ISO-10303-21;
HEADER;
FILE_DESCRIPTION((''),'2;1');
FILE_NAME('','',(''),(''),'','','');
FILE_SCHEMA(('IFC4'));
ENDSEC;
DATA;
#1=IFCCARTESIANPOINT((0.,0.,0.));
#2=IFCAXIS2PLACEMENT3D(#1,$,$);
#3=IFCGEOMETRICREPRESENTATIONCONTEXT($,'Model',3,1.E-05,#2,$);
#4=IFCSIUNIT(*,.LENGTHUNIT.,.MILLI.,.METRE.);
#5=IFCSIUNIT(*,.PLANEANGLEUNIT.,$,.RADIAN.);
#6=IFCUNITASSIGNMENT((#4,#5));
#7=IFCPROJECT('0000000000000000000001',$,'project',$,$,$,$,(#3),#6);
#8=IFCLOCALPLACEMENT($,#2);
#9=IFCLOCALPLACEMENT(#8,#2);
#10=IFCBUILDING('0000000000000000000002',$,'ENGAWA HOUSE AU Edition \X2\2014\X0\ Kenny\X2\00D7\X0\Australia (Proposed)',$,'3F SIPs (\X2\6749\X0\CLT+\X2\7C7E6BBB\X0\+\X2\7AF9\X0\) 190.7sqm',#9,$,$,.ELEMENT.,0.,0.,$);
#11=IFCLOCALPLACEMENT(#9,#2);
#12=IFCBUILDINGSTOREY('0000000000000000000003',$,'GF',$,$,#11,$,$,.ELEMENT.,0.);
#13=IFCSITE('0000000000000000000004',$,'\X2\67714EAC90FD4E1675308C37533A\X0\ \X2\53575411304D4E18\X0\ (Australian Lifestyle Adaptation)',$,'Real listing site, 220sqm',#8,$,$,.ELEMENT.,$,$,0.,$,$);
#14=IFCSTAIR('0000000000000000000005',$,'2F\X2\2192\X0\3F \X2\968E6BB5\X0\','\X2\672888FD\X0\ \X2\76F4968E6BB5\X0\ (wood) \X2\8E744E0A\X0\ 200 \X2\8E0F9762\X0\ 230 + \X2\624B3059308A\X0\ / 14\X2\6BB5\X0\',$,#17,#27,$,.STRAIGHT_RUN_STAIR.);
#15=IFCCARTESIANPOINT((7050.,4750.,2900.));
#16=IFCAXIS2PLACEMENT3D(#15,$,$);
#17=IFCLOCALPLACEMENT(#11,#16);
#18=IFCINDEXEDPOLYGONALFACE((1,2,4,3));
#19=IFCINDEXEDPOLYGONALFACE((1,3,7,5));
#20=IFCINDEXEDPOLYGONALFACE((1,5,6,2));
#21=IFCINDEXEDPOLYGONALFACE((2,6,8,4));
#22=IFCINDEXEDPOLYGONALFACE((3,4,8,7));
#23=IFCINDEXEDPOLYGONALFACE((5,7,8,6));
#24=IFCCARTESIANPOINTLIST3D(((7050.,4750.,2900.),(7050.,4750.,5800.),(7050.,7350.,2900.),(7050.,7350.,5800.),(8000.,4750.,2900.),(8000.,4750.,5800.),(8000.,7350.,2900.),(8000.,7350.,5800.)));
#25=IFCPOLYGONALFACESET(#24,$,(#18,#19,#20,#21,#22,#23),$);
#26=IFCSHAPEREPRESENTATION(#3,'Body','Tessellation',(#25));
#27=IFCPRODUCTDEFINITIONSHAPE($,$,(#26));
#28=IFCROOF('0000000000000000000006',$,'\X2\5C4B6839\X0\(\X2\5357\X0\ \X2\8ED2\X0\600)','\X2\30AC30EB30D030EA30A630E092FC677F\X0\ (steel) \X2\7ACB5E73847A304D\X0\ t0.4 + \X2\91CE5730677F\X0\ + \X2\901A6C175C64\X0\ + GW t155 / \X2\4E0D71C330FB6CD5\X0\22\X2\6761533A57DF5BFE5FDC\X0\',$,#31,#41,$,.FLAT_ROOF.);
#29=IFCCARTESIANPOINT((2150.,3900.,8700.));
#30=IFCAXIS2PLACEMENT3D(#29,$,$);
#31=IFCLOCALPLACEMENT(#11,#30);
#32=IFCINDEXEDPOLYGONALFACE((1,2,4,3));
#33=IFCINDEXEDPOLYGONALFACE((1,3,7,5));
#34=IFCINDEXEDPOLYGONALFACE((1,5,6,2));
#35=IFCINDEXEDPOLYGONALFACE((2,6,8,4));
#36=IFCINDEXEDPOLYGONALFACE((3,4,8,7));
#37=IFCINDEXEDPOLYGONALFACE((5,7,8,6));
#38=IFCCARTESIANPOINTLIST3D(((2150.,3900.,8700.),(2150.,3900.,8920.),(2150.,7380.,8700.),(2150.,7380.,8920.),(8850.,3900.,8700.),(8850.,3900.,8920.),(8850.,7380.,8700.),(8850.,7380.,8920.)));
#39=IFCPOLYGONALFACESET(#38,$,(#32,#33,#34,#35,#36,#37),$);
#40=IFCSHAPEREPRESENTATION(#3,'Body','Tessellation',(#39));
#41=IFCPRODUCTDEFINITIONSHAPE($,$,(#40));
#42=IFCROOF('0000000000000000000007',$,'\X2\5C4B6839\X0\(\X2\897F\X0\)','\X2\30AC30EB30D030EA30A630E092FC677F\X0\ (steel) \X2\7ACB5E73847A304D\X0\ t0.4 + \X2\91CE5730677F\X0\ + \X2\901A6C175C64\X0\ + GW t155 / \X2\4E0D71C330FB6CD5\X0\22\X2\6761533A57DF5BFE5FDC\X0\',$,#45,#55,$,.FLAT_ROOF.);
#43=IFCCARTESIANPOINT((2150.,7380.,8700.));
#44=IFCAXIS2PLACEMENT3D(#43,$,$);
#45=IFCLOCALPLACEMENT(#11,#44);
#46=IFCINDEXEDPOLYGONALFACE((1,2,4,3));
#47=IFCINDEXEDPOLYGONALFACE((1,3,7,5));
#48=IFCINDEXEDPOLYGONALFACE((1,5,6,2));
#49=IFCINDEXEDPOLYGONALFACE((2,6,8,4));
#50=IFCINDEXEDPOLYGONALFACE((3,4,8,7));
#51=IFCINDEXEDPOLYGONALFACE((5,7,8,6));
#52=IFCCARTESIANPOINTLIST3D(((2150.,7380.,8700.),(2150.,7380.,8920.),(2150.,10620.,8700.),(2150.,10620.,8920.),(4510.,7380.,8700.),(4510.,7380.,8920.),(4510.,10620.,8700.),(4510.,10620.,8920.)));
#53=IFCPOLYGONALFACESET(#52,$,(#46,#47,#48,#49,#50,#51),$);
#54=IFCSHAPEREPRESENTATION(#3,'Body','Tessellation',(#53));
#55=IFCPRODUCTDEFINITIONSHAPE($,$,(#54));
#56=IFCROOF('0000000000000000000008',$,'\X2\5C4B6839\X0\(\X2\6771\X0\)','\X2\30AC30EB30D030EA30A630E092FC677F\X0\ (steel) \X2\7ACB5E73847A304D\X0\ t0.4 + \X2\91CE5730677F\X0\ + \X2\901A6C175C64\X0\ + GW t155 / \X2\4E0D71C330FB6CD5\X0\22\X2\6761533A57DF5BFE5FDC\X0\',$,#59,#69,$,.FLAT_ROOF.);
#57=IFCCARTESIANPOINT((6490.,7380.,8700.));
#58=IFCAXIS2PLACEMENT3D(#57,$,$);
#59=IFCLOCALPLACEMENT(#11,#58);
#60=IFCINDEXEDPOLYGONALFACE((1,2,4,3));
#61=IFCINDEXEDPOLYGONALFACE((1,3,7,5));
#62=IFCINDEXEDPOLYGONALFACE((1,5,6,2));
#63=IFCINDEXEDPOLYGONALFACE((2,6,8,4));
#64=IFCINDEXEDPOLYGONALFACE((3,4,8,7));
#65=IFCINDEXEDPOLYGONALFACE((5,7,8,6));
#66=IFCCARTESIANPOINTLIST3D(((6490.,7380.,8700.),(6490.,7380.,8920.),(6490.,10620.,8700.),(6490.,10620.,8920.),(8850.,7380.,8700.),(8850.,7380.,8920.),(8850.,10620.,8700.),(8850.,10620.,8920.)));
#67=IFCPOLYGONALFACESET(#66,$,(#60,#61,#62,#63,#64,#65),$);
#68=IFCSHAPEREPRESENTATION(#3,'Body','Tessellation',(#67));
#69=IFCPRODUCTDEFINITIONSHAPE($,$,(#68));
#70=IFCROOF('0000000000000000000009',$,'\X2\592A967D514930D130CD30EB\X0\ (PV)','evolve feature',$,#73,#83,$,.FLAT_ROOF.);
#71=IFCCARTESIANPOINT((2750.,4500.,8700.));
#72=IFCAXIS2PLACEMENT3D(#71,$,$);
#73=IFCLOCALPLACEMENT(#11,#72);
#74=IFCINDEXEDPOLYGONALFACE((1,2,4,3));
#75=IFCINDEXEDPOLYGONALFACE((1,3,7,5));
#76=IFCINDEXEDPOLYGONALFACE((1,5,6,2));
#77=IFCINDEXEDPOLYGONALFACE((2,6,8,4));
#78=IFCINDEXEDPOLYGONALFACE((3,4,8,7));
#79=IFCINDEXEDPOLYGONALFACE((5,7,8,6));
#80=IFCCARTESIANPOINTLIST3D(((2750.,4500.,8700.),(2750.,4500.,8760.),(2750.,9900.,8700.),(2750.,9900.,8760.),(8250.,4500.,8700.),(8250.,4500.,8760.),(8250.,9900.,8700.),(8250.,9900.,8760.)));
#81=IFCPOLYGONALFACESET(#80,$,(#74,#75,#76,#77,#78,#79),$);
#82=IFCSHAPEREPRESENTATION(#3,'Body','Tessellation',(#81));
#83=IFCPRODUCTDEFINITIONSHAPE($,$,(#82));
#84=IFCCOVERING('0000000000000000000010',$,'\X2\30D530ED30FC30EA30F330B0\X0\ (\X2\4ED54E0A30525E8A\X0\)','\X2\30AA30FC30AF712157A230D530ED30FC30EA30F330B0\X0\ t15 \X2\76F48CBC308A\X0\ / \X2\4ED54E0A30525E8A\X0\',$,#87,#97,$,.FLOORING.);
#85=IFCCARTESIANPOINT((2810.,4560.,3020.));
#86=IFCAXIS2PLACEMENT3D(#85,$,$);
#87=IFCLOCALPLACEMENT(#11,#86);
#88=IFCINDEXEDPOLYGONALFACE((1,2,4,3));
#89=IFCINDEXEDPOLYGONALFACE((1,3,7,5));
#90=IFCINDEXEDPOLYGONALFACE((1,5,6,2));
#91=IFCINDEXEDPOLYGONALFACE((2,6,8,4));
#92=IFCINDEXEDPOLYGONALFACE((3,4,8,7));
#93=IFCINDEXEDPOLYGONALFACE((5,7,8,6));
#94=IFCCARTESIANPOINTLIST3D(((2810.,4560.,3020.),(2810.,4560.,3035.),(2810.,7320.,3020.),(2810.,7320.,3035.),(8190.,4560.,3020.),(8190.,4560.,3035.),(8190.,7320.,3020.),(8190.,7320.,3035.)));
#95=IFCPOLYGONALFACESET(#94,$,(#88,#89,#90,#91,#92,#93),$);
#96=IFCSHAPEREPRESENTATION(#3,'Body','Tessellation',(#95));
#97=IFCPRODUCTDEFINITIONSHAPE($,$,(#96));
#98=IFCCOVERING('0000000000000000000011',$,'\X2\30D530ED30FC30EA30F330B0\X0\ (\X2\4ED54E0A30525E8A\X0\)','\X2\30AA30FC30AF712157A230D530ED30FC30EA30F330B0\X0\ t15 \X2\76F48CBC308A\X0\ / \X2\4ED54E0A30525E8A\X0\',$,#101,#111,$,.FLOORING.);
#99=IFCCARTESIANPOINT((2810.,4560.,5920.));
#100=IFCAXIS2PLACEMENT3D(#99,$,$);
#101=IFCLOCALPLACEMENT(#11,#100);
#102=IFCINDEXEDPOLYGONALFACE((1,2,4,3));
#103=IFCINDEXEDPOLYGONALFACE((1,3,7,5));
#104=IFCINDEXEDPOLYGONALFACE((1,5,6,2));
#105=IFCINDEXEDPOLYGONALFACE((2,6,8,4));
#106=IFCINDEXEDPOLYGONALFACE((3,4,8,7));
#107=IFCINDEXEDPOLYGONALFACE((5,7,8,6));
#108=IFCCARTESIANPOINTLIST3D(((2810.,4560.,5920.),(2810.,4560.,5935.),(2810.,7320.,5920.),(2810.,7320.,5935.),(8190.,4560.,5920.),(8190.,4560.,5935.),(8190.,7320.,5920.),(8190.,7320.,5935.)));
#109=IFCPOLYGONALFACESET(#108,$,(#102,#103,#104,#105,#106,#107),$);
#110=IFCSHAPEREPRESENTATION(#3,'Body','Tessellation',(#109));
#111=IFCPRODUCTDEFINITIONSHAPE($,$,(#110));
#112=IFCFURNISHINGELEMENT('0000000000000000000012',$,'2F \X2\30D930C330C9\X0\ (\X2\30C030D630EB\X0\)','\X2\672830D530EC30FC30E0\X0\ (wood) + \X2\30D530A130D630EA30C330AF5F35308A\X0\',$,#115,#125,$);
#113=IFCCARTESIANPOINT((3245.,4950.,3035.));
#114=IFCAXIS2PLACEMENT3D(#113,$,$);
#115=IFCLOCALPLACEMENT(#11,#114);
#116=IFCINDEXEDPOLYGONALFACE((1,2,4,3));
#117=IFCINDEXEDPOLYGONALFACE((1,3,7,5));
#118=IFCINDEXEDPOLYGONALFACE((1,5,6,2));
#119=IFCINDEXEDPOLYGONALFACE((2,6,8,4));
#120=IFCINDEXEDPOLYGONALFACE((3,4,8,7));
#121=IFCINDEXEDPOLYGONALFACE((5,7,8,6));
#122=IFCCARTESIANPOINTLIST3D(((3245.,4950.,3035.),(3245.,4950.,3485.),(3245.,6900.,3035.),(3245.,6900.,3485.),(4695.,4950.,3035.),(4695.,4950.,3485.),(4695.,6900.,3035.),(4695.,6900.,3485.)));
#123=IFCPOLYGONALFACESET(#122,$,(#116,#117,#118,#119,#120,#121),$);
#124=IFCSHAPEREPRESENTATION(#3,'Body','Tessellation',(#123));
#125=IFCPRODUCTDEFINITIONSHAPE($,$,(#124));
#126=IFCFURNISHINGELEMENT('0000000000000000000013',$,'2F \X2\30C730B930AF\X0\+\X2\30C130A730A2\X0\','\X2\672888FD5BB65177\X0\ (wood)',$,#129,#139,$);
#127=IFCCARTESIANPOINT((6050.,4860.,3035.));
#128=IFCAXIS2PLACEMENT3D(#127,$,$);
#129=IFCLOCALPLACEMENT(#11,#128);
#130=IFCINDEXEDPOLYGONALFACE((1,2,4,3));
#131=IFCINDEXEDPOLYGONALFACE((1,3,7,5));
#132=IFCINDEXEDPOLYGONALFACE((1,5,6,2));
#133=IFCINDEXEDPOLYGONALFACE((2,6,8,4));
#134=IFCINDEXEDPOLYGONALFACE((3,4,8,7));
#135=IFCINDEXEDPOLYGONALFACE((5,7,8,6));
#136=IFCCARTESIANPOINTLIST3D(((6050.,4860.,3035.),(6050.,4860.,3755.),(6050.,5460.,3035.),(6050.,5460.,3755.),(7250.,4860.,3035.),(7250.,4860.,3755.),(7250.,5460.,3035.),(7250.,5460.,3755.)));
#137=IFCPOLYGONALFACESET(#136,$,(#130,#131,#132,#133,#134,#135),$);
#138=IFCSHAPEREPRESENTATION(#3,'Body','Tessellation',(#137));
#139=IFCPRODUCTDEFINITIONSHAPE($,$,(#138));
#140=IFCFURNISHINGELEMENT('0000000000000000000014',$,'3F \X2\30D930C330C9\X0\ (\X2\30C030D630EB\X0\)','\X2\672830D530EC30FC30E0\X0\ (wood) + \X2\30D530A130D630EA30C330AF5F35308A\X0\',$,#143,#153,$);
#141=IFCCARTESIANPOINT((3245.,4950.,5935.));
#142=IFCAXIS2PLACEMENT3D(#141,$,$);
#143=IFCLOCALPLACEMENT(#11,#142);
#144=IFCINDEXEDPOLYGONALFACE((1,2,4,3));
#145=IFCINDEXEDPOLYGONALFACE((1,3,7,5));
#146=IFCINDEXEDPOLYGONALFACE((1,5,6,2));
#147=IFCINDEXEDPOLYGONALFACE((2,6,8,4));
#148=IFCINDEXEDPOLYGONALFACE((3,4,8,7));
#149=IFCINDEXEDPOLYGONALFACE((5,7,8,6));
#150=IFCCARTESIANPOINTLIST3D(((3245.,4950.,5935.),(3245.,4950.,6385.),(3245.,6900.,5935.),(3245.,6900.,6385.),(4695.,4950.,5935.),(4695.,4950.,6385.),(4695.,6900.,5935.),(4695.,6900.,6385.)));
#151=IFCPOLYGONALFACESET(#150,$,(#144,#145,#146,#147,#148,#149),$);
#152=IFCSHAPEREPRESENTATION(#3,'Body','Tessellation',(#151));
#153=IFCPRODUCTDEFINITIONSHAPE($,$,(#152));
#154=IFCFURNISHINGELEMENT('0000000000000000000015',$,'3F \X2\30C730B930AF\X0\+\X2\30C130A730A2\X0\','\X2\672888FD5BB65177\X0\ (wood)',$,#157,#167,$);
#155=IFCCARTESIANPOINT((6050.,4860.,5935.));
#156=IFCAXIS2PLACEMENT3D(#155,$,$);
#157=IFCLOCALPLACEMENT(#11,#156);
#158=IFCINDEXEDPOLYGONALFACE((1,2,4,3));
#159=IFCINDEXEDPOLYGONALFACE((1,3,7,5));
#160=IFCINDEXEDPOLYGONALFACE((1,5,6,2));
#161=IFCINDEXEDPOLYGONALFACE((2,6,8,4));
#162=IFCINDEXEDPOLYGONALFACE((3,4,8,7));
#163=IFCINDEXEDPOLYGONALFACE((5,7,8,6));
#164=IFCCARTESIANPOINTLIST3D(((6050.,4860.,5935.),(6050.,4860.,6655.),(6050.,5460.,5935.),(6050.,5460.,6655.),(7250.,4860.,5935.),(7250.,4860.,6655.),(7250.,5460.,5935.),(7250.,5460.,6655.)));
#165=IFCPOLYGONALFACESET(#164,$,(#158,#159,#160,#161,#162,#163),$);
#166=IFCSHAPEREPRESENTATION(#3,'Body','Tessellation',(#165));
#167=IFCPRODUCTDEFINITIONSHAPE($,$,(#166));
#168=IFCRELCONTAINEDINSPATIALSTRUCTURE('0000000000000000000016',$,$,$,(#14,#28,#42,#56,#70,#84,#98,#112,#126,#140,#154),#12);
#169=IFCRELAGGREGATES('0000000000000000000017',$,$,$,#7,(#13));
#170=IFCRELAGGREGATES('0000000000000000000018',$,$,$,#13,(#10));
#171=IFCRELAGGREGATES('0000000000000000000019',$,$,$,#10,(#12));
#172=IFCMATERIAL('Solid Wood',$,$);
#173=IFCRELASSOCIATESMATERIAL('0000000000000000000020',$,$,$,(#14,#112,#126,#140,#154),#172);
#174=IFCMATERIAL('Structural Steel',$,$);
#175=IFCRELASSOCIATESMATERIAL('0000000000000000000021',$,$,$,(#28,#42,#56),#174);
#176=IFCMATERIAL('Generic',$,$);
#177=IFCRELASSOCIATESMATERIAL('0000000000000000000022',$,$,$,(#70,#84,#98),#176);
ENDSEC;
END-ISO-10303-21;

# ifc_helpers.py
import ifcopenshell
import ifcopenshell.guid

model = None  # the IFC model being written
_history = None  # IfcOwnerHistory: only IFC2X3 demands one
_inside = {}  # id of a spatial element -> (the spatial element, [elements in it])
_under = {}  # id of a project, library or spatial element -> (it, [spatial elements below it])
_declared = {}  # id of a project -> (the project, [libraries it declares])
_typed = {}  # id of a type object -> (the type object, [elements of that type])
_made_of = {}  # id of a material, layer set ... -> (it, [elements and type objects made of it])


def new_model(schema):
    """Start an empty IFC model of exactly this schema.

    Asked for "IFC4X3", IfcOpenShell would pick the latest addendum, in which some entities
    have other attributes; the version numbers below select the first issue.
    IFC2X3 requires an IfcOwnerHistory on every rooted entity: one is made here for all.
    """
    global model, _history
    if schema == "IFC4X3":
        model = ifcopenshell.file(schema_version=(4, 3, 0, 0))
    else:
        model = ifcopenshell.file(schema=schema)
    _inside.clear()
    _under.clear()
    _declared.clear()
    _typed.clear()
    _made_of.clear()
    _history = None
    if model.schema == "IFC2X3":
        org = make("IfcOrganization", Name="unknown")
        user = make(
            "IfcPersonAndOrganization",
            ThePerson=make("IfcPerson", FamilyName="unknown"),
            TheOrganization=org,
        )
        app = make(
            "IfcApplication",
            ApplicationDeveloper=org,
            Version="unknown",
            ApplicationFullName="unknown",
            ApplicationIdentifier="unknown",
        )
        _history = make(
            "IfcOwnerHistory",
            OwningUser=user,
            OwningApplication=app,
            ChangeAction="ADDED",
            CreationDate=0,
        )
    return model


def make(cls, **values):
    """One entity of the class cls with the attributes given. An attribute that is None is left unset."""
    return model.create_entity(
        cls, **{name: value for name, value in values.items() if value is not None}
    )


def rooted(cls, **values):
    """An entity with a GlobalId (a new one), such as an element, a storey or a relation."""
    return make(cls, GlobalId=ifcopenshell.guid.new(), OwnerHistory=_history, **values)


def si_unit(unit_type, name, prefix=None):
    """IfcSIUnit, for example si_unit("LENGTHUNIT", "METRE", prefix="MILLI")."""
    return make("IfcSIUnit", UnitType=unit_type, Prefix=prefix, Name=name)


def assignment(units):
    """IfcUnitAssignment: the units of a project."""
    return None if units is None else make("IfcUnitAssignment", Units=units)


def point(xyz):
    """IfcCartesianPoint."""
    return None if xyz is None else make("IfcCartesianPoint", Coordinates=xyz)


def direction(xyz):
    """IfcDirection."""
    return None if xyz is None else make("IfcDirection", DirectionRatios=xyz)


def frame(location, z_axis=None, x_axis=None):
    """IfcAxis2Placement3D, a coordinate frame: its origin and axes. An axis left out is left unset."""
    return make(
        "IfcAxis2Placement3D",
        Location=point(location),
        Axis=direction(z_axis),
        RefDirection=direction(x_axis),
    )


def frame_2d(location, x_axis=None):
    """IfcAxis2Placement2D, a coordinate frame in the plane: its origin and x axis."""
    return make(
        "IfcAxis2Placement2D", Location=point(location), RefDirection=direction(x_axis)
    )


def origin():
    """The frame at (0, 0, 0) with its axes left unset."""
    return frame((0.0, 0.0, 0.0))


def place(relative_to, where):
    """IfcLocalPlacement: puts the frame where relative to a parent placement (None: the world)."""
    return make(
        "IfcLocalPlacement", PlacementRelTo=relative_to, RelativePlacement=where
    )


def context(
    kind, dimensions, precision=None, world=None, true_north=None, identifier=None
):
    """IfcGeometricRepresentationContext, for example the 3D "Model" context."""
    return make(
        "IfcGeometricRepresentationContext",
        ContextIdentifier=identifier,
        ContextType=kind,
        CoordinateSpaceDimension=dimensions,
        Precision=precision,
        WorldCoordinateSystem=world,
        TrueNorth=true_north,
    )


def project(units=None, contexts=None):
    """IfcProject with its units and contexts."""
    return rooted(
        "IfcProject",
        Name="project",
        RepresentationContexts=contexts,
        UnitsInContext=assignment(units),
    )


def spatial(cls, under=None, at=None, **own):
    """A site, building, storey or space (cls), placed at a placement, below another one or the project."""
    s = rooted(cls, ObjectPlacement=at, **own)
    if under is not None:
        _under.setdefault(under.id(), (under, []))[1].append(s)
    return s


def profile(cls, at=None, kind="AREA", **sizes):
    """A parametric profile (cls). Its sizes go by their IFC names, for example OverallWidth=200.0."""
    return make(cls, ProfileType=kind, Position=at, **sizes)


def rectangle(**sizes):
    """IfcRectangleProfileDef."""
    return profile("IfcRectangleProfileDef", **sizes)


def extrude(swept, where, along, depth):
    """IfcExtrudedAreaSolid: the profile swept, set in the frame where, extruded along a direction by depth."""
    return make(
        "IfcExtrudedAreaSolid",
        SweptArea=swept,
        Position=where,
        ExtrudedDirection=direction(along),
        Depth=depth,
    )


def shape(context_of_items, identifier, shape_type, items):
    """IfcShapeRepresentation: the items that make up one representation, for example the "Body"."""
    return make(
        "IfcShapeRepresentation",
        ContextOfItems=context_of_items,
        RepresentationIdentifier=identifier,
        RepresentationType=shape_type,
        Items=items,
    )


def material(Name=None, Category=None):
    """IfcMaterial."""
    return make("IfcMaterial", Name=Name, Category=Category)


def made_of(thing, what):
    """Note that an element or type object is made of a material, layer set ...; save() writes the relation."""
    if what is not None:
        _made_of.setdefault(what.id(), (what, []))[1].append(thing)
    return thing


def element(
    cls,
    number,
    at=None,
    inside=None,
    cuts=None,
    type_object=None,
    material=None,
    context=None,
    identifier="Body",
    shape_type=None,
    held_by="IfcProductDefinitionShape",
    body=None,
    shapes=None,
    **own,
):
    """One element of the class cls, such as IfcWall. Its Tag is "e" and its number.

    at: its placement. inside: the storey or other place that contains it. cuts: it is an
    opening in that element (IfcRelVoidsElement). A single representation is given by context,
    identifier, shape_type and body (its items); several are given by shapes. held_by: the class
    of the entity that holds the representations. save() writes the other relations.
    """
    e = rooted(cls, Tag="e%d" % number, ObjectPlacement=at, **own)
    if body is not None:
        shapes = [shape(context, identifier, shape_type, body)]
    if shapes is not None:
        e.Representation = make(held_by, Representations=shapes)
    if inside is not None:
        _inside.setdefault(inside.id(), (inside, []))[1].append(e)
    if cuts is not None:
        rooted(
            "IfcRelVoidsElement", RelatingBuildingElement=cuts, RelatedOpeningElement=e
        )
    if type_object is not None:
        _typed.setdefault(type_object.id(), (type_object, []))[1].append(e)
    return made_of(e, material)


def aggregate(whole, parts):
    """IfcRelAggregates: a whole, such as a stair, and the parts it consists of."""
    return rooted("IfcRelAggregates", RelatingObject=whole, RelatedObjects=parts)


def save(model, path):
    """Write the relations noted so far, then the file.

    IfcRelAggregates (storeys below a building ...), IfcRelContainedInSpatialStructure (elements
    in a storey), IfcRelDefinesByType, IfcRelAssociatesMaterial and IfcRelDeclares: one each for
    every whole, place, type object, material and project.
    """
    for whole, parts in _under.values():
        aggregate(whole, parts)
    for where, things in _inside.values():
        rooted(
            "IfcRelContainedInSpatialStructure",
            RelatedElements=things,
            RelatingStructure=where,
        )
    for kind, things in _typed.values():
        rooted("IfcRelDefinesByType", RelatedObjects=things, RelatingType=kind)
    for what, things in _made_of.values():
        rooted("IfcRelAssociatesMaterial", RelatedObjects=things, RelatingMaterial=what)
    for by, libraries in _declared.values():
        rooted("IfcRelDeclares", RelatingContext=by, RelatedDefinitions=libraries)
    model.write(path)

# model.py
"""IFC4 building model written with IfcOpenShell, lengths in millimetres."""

from ifc_helpers import new_model, si_unit, frame, frame_2d, origin, place, context, project, spatial, rectangle, extrude, material, element, save


model = new_model("IFC4")

# Units and contexts
model_context = context("Model", 3, precision=1e-05, world=origin())
ifc_project = project(units=[si_unit("LENGTHUNIT", "METRE", prefix="MILLI"), si_unit("PLANEANGLEUNIT", "RADIAN")], contexts=[model_context])

# Site, building, storey
site_placement = place(None, origin())
site = spatial("IfcSite", under=ifc_project, at=site_placement, Name="東京都世田谷区 南向き丘 (Australian Lifestyle Adaptation)", ObjectType="Real listing site, 220sqm", CompositionType="ELEMENT", RefElevation=0.0)
building_placement = place(site_placement, origin())
building = spatial("IfcBuilding", under=site, at=building_placement, Name="ENGAWA HOUSE AU Edition — Kenny×Australia (Proposed)", ObjectType="3F SIPs (杉CLT+籾殻+竹) 190.7sqm", CompositionType="ELEMENT", ElevationOfRefHeight=0.0, ElevationOfTerrain=0.0)
storey_placement = place(building_placement, origin())
storey = spatial("IfcBuildingStorey", under=building, at=storey_placement, Name="GF", CompositionType="ELEMENT", Elevation=0.0)

# Shared definitions
ifc_material_1 = material(Name="Solid Wood")

# Stair
stair_placement = place(storey_placement, frame((7050.0, 4750.0, 2900.0)))
element("IfcStair", 1, at=stair_placement, inside=storey, material=ifc_material_1, Name="2F→3F 階段", Description="木製 直階段 (wood) 蹴上 200 踏面 230 + 手すり / 14段", PredefinedType="STRAIGHT_RUN_STAIR", context=model_context, shape_type="SweptSolid", body=[
    extrude(rectangle(XDim=950.0, YDim=2600.0, at=frame_2d((475.0, 1300.0))), frame((7050.0, 4750.0, 2900.0)), (0.0, 0.0, 1.0), 2900.0),
])

# Roofs
ifc_material_2 = material(Name="Structural Steel")
roof_1_placement = place(storey_placement, frame((2150.0, 3900.0, 8700.0)))
element("IfcRoof", 2, at=roof_1_placement, inside=storey, material=ifc_material_2, Name="屋根(南 軒600)", Description="ガルバリウム鋼板 (steel) 立平葺き t0.4 + 野地板 + 通気層 + GW t155 / 不燃・法22条区域対応", PredefinedType="FLAT_ROOF", context=model_context, shape_type="SweptSolid", body=[
    extrude(rectangle(XDim=6700.0, YDim=3480.0, at=frame_2d((3350.0, 1740.0))), frame((2150.0, 3900.0, 8700.0)), (0.0, 0.0, 1.0), 220.0),
])
roof_2_placement = place(storey_placement, frame((2150.0, 7380.0, 8700.0)))
element("IfcRoof", 3, at=roof_2_placement, inside=storey, material=ifc_material_2, Name="屋根(西)", Description="ガルバリウム鋼板 (steel) 立平葺き t0.4 + 野地板 + 通気層 + GW t155 / 不燃・法22条区域対応", PredefinedType="FLAT_ROOF", context=model_context, shape_type="SweptSolid", body=[
    extrude(rectangle(XDim=2360.0, YDim=3240.0, at=frame_2d((1180.0, 1620.0))), frame((2150.0, 7380.0, 8700.0)), (0.0, 0.0, 1.0), 220.0),
])
roof_3_placement = place(storey_placement, frame((6490.0, 7380.0, 8700.0)))
element("IfcRoof", 4, at=roof_3_placement, inside=storey, material=ifc_material_2, Name="屋根(東)", Description="ガルバリウム鋼板 (steel) 立平葺き t0.4 + 野地板 + 通気層 + GW t155 / 不燃・法22条区域対応", PredefinedType="FLAT_ROOF", context=model_context, shape_type="SweptSolid", body=[
    extrude(rectangle(XDim=2360.0, YDim=3240.0, at=frame_2d((1180.0, 1620.0))), frame((6490.0, 7380.0, 8700.0)), (0.0, 0.0, 1.0), 220.0),
])
ifc_material_3 = material(Name="Generic")
roof_4_placement = place(storey_placement, frame((2750.0, 4500.0, 8700.0)))
element("IfcRoof", 5, at=roof_4_placement, inside=storey, material=ifc_material_3, Name="太陽光パネル (PV)", Description="evolve feature", PredefinedType="FLAT_ROOF", context=model_context, shape_type="SweptSolid", body=[
    extrude(rectangle(XDim=5500.0, YDim=5400.0, at=frame_2d((2750.0, 2700.0))), frame((2750.0, 4500.0, 8700.0)), (0.0, 0.0, 1.0), 60.0),
])

# Coverings
covering_1_placement = place(storey_placement, frame((2810.0, 4560.0, 3020.0)))
element("IfcCovering", 6, at=covering_1_placement, inside=storey, material=ifc_material_3, Name="フローリング (仕上げ床)", Description="オーク無垢フローリング t15 直貼り / 仕上げ床", PredefinedType="FLOORING", context=model_context, shape_type="SweptSolid", body=[
    extrude(rectangle(XDim=5380.0, YDim=2760.0, at=frame_2d((2690.0, 1380.0))), frame((2810.0, 4560.0, 3020.0)), (0.0, 0.0, 1.0), 15.0),
])
covering_2_placement = place(storey_placement, frame((2810.0, 4560.0, 5920.0)))
element("IfcCovering", 7, at=covering_2_placement, inside=storey, material=ifc_material_3, Name="フローリング (仕上げ床)", Description="オーク無垢フローリング t15 直貼り / 仕上げ床", PredefinedType="FLOORING", context=model_context, shape_type="SweptSolid", body=[
    extrude(rectangle(XDim=5380.0, YDim=2760.0, at=frame_2d((2690.0, 1380.0))), frame((2810.0, 4560.0, 5920.0)), (0.0, 0.0, 1.0), 15.0),
])

# Furnishing elements
furnishing_1_placement = place(storey_placement, frame((3245.0, 4950.0, 3035.0)))
element("IfcFurnishingElement", 8, at=furnishing_1_placement, inside=storey, material=ifc_material_1, Name="2F ベッド (ダブル)", Description="木フレーム (wood) + ファブリック張り", context=model_context, shape_type="SweptSolid", body=[
    extrude(rectangle(XDim=1450.0, YDim=1950.0, at=frame_2d((725.0, 975.0))), frame((3245.0, 4950.0, 3035.0)), (0.0, 0.0, 1.0), 450.0),
])
furnishing_2_placement = place(storey_placement, frame((6050.0, 4860.0, 3035.0)))
element("IfcFurnishingElement", 9, at=furnishing_2_placement, inside=storey, material=ifc_material_1, Name="2F デスク+チェア", Description="木製家具 (wood)", context=model_context, shape_type="SweptSolid", body=[
    extrude(rectangle(XDim=1200.0, YDim=600.0, at=frame_2d((600.0, 300.0))), frame((6050.0, 4860.0, 3035.0)), (0.0, 0.0, 1.0), 720.0),
])
furnishing_3_placement = place(storey_placement, frame((3245.0, 4950.0, 5935.0)))
element("IfcFurnishingElement", 10, at=furnishing_3_placement, inside=storey, material=ifc_material_1, Name="3F ベッド (ダブル)", Description="木フレーム (wood) + ファブリック張り", context=model_context, shape_type="SweptSolid", body=[
    extrude(rectangle(XDim=1450.0, YDim=1950.0, at=frame_2d((725.0, 975.0))), frame((3245.0, 4950.0, 5935.0)), (0.0, 0.0, 1.0), 450.0),
])
furnishing_4_placement = place(storey_placement, frame((6050.0, 4860.0, 5935.0)))
element("IfcFurnishingElement", 11, at=furnishing_4_placement, inside=storey, material=ifc_material_1, Name="3F デスク+チェア", Description="木製家具 (wood)", context=model_context, shape_type="SweptSolid", body=[
    extrude(rectangle(XDim=1200.0, YDim=600.0, at=frame_2d((600.0, 300.0))), frame((6050.0, 4860.0, 5935.0)), (0.0, 0.0, 1.0), 720.0),
])

save(model, "model.ifc")
